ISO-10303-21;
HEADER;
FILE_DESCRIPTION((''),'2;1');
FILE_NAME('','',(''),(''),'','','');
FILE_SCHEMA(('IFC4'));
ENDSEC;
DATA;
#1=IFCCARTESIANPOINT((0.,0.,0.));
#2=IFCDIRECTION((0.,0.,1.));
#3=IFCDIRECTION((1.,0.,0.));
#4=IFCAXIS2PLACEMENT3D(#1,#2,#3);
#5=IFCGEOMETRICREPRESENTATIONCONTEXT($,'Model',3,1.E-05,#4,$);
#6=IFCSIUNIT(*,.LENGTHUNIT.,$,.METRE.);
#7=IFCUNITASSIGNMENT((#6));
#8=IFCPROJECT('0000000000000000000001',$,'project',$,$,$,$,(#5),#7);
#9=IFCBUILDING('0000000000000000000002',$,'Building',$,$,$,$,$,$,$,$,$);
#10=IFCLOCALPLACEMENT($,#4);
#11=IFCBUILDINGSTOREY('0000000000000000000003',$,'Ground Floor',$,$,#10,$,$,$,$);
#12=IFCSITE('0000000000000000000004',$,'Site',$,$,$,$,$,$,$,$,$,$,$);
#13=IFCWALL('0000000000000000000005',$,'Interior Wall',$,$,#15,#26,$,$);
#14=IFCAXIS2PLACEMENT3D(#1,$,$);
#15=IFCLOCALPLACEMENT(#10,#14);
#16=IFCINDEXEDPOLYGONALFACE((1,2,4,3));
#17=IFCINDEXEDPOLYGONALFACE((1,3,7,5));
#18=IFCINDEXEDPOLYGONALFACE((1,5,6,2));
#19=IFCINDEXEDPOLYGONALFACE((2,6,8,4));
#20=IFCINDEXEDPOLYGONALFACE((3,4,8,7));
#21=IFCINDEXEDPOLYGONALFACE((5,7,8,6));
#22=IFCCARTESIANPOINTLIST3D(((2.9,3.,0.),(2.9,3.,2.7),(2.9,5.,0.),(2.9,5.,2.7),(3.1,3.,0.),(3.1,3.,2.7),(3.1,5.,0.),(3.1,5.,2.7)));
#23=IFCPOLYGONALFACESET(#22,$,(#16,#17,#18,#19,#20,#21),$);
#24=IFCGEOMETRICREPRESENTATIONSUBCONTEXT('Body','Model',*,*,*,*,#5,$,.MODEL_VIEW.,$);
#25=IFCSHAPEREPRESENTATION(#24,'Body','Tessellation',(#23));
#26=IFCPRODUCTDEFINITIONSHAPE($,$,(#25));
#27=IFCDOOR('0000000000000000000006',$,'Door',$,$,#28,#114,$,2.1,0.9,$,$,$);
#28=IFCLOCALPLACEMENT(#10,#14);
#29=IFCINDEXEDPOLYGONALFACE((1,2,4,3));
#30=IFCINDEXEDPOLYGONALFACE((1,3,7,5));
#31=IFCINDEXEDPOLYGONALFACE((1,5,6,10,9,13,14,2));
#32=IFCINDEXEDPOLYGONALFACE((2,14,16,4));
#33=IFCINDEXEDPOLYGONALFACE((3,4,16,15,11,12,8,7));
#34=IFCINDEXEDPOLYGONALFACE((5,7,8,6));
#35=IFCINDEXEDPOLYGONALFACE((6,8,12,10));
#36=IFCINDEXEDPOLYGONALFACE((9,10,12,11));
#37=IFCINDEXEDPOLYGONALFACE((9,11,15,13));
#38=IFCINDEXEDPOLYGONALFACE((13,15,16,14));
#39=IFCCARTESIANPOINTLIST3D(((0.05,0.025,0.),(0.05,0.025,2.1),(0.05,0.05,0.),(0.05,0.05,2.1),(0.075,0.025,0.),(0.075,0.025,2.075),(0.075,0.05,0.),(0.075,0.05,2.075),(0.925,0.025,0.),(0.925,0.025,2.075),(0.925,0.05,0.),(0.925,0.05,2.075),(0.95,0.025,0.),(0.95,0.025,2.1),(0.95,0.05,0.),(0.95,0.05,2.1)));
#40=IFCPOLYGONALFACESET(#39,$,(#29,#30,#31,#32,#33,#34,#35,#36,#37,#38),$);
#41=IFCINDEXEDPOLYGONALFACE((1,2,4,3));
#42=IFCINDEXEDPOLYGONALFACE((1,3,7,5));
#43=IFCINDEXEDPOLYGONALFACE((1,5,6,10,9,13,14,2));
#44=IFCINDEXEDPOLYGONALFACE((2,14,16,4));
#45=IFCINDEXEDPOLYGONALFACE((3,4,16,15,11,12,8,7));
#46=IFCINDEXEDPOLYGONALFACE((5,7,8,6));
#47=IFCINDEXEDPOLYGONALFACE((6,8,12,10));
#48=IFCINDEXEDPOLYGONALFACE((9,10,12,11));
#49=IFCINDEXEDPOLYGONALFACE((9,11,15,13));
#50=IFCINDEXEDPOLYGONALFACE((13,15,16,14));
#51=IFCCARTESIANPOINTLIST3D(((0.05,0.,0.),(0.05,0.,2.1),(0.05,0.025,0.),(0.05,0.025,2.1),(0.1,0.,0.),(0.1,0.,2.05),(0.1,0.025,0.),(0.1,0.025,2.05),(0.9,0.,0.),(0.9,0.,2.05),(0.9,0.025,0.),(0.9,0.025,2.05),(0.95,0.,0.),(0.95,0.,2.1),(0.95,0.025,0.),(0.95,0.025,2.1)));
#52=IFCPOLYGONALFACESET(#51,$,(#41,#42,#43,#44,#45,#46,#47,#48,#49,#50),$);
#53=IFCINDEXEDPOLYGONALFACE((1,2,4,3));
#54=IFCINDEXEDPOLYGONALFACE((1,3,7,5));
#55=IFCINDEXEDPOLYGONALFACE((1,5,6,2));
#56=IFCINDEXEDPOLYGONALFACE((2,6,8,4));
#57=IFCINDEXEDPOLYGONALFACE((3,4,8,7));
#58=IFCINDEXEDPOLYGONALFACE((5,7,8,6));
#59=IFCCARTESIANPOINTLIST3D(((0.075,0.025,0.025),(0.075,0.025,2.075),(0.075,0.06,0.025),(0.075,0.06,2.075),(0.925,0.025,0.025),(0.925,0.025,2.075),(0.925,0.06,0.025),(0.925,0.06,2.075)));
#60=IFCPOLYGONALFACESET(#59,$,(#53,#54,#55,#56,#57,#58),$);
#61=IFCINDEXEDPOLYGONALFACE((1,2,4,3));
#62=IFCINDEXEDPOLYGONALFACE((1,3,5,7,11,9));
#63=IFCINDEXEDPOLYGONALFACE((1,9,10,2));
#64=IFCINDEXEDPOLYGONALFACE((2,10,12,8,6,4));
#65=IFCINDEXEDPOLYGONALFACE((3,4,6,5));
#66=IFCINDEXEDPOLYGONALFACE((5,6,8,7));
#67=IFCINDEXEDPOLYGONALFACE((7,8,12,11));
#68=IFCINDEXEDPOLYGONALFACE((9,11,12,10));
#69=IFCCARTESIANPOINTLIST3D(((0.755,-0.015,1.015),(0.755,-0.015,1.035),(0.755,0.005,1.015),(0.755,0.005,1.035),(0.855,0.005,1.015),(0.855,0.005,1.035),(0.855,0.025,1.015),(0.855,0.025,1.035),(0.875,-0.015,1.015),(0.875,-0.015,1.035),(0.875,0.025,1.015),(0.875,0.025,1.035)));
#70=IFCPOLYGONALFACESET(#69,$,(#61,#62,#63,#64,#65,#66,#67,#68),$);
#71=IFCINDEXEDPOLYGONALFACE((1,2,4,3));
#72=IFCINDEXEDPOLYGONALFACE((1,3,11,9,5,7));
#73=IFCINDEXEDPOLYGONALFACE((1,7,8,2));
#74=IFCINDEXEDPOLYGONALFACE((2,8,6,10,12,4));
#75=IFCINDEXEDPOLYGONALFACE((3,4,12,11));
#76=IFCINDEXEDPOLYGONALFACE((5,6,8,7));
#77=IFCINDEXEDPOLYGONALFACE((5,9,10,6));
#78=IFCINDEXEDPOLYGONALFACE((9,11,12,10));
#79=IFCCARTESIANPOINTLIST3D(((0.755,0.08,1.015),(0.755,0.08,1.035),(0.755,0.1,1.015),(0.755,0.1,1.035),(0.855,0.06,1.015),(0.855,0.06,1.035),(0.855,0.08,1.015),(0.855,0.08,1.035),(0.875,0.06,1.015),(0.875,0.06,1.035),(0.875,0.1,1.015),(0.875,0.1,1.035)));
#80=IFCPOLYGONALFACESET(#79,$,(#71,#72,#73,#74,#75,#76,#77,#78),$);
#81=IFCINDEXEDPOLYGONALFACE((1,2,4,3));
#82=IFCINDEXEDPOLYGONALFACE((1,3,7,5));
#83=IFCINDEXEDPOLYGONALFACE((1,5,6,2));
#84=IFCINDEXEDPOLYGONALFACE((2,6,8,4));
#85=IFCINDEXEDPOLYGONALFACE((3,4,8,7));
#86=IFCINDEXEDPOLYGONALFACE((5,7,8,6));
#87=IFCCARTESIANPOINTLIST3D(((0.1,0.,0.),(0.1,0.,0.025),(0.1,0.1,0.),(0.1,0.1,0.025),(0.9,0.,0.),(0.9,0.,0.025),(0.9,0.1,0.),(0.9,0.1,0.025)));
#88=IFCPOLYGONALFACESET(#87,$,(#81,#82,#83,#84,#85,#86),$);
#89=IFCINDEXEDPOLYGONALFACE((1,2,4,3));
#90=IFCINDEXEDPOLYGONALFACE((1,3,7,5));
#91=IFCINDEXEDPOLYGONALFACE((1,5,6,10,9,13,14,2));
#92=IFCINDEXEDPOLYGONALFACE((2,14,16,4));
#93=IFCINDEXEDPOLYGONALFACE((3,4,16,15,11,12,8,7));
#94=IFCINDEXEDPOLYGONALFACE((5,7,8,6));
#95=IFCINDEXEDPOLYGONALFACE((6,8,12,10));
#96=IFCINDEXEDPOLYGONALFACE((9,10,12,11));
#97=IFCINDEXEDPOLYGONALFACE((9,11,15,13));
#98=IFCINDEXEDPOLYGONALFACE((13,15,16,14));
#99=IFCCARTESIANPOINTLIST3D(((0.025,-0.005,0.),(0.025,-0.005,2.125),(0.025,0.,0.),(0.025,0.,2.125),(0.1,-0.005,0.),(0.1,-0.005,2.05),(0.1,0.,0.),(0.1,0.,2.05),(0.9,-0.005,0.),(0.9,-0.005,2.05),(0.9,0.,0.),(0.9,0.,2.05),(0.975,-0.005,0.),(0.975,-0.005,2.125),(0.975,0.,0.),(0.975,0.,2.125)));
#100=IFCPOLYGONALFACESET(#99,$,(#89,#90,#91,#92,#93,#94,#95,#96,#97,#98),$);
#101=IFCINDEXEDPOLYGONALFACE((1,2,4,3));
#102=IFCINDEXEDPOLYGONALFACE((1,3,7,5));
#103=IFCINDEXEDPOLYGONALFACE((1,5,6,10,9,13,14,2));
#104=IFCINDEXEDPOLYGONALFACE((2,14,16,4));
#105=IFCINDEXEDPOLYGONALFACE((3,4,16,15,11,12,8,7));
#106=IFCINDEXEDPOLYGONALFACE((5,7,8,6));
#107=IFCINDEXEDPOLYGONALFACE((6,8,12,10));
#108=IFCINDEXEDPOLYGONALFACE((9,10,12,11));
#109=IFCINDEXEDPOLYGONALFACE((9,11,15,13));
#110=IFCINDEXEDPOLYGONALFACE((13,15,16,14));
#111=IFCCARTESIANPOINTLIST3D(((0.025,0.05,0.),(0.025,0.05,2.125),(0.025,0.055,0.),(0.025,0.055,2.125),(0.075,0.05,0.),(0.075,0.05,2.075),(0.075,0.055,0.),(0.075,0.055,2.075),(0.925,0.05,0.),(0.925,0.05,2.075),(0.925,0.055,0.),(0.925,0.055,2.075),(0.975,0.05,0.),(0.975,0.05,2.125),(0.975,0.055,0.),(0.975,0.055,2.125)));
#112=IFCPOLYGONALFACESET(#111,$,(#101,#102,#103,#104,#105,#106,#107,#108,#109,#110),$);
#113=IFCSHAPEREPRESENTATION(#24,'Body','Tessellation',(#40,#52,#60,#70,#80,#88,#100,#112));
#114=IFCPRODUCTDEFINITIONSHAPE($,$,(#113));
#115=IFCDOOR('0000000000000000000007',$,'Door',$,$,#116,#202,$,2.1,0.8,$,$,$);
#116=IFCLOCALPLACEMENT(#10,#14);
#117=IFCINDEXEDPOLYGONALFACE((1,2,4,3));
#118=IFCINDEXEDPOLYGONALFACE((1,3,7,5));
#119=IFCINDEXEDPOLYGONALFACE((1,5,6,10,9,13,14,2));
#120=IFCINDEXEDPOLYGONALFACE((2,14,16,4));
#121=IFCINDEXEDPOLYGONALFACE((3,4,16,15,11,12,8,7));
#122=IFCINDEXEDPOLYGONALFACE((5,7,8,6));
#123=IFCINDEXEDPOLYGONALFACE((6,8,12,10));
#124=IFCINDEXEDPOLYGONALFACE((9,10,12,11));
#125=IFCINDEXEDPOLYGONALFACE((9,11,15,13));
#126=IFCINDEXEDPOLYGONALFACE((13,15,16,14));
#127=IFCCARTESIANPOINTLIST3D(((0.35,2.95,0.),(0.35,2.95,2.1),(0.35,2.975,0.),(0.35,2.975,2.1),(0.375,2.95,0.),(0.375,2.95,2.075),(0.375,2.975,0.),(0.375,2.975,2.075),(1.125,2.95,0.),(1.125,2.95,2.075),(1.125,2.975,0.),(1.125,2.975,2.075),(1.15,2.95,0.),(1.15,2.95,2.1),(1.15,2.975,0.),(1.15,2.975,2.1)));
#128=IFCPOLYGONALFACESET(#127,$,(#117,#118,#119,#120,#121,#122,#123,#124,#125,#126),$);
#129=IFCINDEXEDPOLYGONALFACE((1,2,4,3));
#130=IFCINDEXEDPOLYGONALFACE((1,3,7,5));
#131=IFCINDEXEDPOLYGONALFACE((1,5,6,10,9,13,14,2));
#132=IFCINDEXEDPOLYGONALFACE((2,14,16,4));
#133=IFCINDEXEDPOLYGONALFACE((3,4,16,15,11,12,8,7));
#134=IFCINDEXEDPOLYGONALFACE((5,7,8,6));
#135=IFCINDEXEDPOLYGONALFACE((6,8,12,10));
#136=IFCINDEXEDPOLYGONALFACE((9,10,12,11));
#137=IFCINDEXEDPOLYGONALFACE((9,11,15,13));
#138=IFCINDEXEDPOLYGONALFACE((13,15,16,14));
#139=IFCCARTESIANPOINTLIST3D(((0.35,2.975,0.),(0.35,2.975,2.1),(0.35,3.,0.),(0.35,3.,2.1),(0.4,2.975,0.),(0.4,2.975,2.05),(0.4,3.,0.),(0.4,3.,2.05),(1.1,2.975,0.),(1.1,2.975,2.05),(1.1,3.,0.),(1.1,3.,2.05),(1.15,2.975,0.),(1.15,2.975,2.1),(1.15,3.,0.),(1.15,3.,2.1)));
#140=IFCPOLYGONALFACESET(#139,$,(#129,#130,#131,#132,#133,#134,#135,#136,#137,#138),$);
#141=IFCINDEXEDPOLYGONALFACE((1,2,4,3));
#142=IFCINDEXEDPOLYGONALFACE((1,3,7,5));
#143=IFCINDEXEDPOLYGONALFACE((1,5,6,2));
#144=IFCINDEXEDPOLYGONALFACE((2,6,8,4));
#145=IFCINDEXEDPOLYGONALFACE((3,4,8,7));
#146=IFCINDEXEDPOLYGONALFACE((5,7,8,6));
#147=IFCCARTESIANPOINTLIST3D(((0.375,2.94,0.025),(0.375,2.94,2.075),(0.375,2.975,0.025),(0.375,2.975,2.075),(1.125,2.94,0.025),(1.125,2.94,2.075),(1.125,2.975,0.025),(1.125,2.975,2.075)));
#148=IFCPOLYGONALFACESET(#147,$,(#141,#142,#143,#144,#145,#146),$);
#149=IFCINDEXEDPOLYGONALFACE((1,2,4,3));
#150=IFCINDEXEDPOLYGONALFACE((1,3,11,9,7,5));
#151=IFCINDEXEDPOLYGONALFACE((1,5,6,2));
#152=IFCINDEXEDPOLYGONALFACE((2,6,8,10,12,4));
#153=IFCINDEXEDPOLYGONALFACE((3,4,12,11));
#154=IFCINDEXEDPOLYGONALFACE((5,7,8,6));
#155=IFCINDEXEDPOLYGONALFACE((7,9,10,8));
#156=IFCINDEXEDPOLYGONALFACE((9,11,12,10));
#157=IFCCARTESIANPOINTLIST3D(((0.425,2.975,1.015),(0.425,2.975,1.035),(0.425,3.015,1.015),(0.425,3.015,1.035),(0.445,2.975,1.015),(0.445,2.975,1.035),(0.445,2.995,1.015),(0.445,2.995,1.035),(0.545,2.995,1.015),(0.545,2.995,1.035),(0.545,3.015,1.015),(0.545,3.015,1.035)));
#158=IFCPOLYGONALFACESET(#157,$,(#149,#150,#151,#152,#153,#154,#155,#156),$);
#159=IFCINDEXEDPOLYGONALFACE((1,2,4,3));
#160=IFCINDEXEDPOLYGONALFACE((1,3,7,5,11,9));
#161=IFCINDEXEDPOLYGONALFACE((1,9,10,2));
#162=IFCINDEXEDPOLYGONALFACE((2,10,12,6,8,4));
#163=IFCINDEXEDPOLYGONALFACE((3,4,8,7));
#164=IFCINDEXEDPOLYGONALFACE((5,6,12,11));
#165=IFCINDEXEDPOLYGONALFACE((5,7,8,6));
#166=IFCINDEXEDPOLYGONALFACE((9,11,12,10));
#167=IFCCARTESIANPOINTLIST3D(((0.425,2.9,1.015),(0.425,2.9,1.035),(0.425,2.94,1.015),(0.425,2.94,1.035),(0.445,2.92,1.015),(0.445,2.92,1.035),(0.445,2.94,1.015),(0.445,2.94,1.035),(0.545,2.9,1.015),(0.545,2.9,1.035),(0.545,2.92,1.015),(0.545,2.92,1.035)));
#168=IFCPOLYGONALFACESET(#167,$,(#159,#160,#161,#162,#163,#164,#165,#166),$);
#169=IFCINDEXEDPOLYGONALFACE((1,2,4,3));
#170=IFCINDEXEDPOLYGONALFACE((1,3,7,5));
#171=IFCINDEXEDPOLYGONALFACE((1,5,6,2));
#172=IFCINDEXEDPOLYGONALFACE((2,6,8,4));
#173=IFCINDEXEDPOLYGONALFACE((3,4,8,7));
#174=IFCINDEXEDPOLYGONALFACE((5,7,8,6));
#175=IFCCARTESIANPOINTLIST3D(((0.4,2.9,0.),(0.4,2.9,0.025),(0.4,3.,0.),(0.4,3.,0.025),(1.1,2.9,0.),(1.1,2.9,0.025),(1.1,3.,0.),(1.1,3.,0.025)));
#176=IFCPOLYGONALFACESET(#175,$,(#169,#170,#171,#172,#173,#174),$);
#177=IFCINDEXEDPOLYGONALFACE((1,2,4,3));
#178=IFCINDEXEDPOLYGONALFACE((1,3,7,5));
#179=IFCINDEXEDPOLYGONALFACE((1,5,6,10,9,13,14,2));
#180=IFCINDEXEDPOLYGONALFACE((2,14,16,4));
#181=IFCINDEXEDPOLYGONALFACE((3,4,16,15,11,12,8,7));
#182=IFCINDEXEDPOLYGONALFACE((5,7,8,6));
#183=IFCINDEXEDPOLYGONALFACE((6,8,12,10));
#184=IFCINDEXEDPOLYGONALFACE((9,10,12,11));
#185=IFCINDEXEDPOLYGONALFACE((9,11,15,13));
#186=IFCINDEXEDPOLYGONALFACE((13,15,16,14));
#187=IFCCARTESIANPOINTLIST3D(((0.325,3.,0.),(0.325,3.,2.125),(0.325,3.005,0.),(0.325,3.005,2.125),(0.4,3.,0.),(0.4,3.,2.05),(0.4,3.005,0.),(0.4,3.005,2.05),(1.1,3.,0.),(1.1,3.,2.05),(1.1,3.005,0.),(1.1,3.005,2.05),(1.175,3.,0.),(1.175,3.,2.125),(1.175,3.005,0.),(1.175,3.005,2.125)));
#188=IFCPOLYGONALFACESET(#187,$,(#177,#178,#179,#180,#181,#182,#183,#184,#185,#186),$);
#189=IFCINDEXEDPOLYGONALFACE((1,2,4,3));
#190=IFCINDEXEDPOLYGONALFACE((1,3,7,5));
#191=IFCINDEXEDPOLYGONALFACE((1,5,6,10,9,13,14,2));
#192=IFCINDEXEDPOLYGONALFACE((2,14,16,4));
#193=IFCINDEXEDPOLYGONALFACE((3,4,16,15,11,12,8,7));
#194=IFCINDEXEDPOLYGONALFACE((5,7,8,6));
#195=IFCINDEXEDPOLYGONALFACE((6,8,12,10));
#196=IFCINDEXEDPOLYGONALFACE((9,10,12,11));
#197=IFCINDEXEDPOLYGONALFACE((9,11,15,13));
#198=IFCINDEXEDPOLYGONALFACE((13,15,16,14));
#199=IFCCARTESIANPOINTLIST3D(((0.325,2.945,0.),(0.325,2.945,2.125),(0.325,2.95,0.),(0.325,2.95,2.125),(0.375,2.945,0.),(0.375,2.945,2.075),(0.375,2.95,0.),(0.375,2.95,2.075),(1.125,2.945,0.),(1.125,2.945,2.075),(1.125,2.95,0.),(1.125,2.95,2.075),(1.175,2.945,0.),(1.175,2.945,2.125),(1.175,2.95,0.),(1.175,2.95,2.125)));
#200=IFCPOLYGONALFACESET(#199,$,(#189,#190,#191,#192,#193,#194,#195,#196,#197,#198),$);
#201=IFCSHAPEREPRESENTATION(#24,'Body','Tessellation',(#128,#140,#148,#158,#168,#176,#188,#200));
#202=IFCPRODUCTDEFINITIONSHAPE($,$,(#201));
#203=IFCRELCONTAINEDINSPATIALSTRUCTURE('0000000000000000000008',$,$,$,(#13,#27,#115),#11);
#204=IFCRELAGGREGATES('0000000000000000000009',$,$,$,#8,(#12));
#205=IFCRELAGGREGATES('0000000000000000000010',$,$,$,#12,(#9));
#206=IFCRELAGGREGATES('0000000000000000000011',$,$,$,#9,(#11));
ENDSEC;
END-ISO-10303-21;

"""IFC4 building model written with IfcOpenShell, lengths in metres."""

from ifc_helpers import new_model, si_unit, frame, origin_with_axes, place, context, subcontext, project, spatial, line, indexed_curve, outline, extrude, element, save


model = new_model("IFC4")

# Units and contexts
model_context = context("Model", 3, precision=1e-05, world=origin_with_axes())
body_context = subcontext(model_context, "Body", "Model", "MODEL_VIEW")
ifc_project = project(units=[si_unit("LENGTHUNIT", "METRE")], contexts=[model_context])

# Site, building, storey
site = spatial("IfcSite", under=ifc_project, Name="Site")
building = spatial("IfcBuilding", under=site, Name="Building")
storey_placement = place(None, origin_with_axes())
storey = spatial("IfcBuildingStorey", under=building, at=storey_placement, Name="Ground Floor")

# Wall
for number, where, z_axis, x_axis, name in (
    (1, (3.0, 3.0, 0.0), (0.0, 0.0, 1.0), (0.0, 1.0, 0.0), "Interior Wall"),
):
    element("IfcWall", number, at=place(storey_placement, frame(where, z_axis=z_axis, x_axis=x_axis)), inside=storey, Name=name, context=body_context, shape_type="SweptSolid", body=[
        extrude(outline(indexed_curve([(0.0, 0.0), (0.0, 0.2), (2.0, 0.2), (2.0, 0.0), (0.0, 0.0)], self_intersect=False)), frame((0.0, -0.1, 0.0), z_axis=(0.0, 0.0, 1.0), x_axis=(1.0, 0.0, 0.0)), (0.0, 0.0, 1.0), 2.7),
    ])

# Doors
door_1_placement = place(storey_placement, frame((0.05, 0.0, 0.0), z_axis=(0.0, 0.0, 1.0), x_axis=(1.0, 0.0, 0.0)))
element("IfcDoor", 2, at=door_1_placement, inside=storey, Name="Door", OverallHeight=2.1, OverallWidth=0.9, context=body_context, shape_type="SweptSolid", body=[
    extrude(outline(indexed_curve([(0.0, 0.0), (0.0, 2.1), (0.9, 2.1), (0.9, 0.0), (0.875, 0.0), (0.875, 2.075), (0.025, 2.075), (0.025, 0.0)], segments=[line(1, 2, 3, 4, 5, 6, 7, 8, 1)])), frame((0.0, 0.025, 0.0), z_axis=(0.0, -1.0, 0.0), x_axis=(1.0, 0.0, 0.0)), (0.0, 0.0, -1.0), 0.025),
    extrude(outline(indexed_curve([(0.0, 0.0), (0.0, 2.1), (0.9, 2.1), (0.9, 0.0), (0.85, 0.0), (0.85, 2.05), (0.05, 2.05), (0.05, 0.0)], segments=[line(1, 2, 3, 4, 5, 6, 7, 8, 1)])), frame((0.0, 0.0, 0.0), z_axis=(0.0, -1.0, 0.0), x_axis=(1.0, 0.0, 0.0)), (0.0, 0.0, -1.0), 0.025),
    extrude(outline(indexed_curve([(0.0, 0.0), (0.85, 0.0), (0.85, 0.035), (0.0, 0.035)], segments=[line(1, 2, 3, 4, 1)])), frame((0.025, 0.025, 0.025), z_axis=(0.0, 0.0, 1.0), x_axis=(1.0, 0.0, 0.0)), (0.0, 0.0, 1.0), 2.05),
    extrude(outline(indexed_curve([(0.0, 0.0), (0.0, -0.04), (-0.12, -0.04), (-0.12, -0.02), (-0.02, -0.02), (-0.02, 0.0)], segments=[line(1, 2, 3, 4, 5, 6, 1)])), frame((0.825, 0.025, 1.015), z_axis=(0.0, 0.0, 1.0), x_axis=(1.0, 0.0, 0.0)), (0.0, 0.0, 1.0), 0.02),
    extrude(outline(indexed_curve([(0.0, 0.0), (0.0, 0.04), (-0.12, 0.04), (-0.12, 0.02), (-0.02, 0.02), (-0.02, 0.0)], segments=[line(1, 2, 3, 4, 5, 6, 1)])), frame((0.825, 0.06, 1.015), z_axis=(0.0, 0.0, 1.0), x_axis=(1.0, 0.0, 0.0)), (0.0, 0.0, 1.0), 0.02),
    extrude(outline(indexed_curve([(0.0, 0.0), (0.8, 0.0), (0.8, 0.1), (0.0, 0.1)], segments=[line(1, 2, 3, 4, 1)])), frame((0.05, 0.0, 0.0), z_axis=(0.0, 0.0, 1.0), x_axis=(1.0, 0.0, 0.0)), (0.0, 0.0, 1.0), 0.025),
    extrude(outline(indexed_curve([(0.0, 0.0), (0.0, 2.125), (0.95, 2.125), (0.95, 0.0), (0.875, 0.0), (0.875, 2.05), (0.075, 2.05), (0.075, 0.0)], segments=[line(1, 2, 3, 4, 5, 6, 7, 8, 1)])), frame((-0.025, -0.005, 0.0), z_axis=(0.0, -1.0, 0.0), x_axis=(1.0, 0.0, 0.0)), (0.0, 0.0, -1.0), 0.005),
    extrude(outline(indexed_curve([(0.0, 0.0), (0.0, 2.125), (0.95, 2.125), (0.95, 0.0), (0.9, 0.0), (0.9, 2.075), (0.05, 2.075), (0.05, 0.0)], segments=[line(1, 2, 3, 4, 5, 6, 7, 8, 1)])), frame((-0.025, 0.05, 0.0), z_axis=(0.0, -1.0, 0.0), x_axis=(1.0, 0.0, 0.0)), (0.0, 0.0, -1.0), 0.005),
])
door_2_placement = place(storey_placement, frame((1.15, 3.0, 0.0), z_axis=(0.0, 0.0, 1.0), x_axis=(-1.0, 0.0, 0.0)))
element("IfcDoor", 3, at=door_2_placement, inside=storey, Name="Door", OverallHeight=2.1, OverallWidth=0.8, context=body_context, shape_type="SweptSolid", body=[
    extrude(outline(indexed_curve([(0.0, 0.0), (0.0, 2.1), (0.8, 2.1), (0.8, 0.0), (0.775, 0.0), (0.775, 2.075), (0.025, 2.075), (0.025, 0.0)], segments=[line(1, 2, 3, 4, 5, 6, 7, 8, 1)])), frame((0.0, 0.025, 0.0), z_axis=(0.0, -1.0, 0.0), x_axis=(1.0, 0.0, 0.0)), (0.0, 0.0, -1.0), 0.025),
    extrude(outline(indexed_curve([(0.0, 0.0), (0.0, 2.1), (0.8, 2.1), (0.8, 0.0), (0.75, 0.0), (0.75, 2.05), (0.05, 2.05), (0.05, 0.0)], segments=[line(1, 2, 3, 4, 5, 6, 7, 8, 1)])), frame((0.0, 0.0, 0.0), z_axis=(0.0, -1.0, 0.0), x_axis=(1.0, 0.0, 0.0)), (0.0, 0.0, -1.0), 0.025),
    extrude(outline(indexed_curve([(0.0, 0.0), (0.75, 0.0), (0.75, 0.035), (0.0, 0.035)], segments=[line(1, 2, 3, 4, 1)])), frame((0.025, 0.025, 0.025), z_axis=(0.0, 0.0, 1.0), x_axis=(1.0, 0.0, 0.0)), (0.0, 0.0, 1.0), 2.05),
    extrude(outline(indexed_curve([(0.0, 0.0), (0.0, -0.04), (-0.12, -0.04), (-0.12, -0.02), (-0.02, -0.02), (-0.02, 0.0)], segments=[line(1, 2, 3, 4, 5, 6, 1)])), frame((0.725, 0.025, 1.015), z_axis=(0.0, 0.0, 1.0), x_axis=(1.0, 0.0, 0.0)), (0.0, 0.0, 1.0), 0.02),
    extrude(outline(indexed_curve([(0.0, 0.0), (0.0, 0.04), (-0.12, 0.04), (-0.12, 0.02), (-0.02, 0.02), (-0.02, 0.0)], segments=[line(1, 2, 3, 4, 5, 6, 1)])), frame((0.725, 0.06, 1.015), z_axis=(0.0, 0.0, 1.0), x_axis=(1.0, 0.0, 0.0)), (0.0, 0.0, 1.0), 0.02),
    extrude(outline(indexed_curve([(0.0, 0.0), (0.7, 0.0), (0.7, 0.1), (0.0, 0.1)], segments=[line(1, 2, 3, 4, 1)])), frame((0.05, 0.0, 0.0), z_axis=(0.0, 0.0, 1.0), x_axis=(1.0, 0.0, 0.0)), (0.0, 0.0, 1.0), 0.025),
    extrude(outline(indexed_curve([(0.0, 0.0), (0.0, 2.125), (0.85, 2.125), (0.85, 0.0), (0.775, 0.0), (0.775, 2.05), (0.075, 2.05), (0.075, 0.0)], segments=[line(1, 2, 3, 4, 5, 6, 7, 8, 1)])), frame((-0.025, -0.005, 0.0), z_axis=(0.0, -1.0, 0.0), x_axis=(1.0, 0.0, 0.0)), (0.0, 0.0, -1.0), 0.005),
    extrude(outline(indexed_curve([(0.0, 0.0), (0.0, 2.125), (0.85, 2.125), (0.85, 0.0), (0.8, 0.0), (0.8, 2.075), (0.05, 2.075), (0.05, 0.0)], segments=[line(1, 2, 3, 4, 5, 6, 7, 8, 1)])), frame((-0.025, 0.05, 0.0), z_axis=(0.0, -1.0, 0.0), x_axis=(1.0, 0.0, 0.0)), (0.0, 0.0, -1.0), 0.005),
])

save(model, "model.ifc")
